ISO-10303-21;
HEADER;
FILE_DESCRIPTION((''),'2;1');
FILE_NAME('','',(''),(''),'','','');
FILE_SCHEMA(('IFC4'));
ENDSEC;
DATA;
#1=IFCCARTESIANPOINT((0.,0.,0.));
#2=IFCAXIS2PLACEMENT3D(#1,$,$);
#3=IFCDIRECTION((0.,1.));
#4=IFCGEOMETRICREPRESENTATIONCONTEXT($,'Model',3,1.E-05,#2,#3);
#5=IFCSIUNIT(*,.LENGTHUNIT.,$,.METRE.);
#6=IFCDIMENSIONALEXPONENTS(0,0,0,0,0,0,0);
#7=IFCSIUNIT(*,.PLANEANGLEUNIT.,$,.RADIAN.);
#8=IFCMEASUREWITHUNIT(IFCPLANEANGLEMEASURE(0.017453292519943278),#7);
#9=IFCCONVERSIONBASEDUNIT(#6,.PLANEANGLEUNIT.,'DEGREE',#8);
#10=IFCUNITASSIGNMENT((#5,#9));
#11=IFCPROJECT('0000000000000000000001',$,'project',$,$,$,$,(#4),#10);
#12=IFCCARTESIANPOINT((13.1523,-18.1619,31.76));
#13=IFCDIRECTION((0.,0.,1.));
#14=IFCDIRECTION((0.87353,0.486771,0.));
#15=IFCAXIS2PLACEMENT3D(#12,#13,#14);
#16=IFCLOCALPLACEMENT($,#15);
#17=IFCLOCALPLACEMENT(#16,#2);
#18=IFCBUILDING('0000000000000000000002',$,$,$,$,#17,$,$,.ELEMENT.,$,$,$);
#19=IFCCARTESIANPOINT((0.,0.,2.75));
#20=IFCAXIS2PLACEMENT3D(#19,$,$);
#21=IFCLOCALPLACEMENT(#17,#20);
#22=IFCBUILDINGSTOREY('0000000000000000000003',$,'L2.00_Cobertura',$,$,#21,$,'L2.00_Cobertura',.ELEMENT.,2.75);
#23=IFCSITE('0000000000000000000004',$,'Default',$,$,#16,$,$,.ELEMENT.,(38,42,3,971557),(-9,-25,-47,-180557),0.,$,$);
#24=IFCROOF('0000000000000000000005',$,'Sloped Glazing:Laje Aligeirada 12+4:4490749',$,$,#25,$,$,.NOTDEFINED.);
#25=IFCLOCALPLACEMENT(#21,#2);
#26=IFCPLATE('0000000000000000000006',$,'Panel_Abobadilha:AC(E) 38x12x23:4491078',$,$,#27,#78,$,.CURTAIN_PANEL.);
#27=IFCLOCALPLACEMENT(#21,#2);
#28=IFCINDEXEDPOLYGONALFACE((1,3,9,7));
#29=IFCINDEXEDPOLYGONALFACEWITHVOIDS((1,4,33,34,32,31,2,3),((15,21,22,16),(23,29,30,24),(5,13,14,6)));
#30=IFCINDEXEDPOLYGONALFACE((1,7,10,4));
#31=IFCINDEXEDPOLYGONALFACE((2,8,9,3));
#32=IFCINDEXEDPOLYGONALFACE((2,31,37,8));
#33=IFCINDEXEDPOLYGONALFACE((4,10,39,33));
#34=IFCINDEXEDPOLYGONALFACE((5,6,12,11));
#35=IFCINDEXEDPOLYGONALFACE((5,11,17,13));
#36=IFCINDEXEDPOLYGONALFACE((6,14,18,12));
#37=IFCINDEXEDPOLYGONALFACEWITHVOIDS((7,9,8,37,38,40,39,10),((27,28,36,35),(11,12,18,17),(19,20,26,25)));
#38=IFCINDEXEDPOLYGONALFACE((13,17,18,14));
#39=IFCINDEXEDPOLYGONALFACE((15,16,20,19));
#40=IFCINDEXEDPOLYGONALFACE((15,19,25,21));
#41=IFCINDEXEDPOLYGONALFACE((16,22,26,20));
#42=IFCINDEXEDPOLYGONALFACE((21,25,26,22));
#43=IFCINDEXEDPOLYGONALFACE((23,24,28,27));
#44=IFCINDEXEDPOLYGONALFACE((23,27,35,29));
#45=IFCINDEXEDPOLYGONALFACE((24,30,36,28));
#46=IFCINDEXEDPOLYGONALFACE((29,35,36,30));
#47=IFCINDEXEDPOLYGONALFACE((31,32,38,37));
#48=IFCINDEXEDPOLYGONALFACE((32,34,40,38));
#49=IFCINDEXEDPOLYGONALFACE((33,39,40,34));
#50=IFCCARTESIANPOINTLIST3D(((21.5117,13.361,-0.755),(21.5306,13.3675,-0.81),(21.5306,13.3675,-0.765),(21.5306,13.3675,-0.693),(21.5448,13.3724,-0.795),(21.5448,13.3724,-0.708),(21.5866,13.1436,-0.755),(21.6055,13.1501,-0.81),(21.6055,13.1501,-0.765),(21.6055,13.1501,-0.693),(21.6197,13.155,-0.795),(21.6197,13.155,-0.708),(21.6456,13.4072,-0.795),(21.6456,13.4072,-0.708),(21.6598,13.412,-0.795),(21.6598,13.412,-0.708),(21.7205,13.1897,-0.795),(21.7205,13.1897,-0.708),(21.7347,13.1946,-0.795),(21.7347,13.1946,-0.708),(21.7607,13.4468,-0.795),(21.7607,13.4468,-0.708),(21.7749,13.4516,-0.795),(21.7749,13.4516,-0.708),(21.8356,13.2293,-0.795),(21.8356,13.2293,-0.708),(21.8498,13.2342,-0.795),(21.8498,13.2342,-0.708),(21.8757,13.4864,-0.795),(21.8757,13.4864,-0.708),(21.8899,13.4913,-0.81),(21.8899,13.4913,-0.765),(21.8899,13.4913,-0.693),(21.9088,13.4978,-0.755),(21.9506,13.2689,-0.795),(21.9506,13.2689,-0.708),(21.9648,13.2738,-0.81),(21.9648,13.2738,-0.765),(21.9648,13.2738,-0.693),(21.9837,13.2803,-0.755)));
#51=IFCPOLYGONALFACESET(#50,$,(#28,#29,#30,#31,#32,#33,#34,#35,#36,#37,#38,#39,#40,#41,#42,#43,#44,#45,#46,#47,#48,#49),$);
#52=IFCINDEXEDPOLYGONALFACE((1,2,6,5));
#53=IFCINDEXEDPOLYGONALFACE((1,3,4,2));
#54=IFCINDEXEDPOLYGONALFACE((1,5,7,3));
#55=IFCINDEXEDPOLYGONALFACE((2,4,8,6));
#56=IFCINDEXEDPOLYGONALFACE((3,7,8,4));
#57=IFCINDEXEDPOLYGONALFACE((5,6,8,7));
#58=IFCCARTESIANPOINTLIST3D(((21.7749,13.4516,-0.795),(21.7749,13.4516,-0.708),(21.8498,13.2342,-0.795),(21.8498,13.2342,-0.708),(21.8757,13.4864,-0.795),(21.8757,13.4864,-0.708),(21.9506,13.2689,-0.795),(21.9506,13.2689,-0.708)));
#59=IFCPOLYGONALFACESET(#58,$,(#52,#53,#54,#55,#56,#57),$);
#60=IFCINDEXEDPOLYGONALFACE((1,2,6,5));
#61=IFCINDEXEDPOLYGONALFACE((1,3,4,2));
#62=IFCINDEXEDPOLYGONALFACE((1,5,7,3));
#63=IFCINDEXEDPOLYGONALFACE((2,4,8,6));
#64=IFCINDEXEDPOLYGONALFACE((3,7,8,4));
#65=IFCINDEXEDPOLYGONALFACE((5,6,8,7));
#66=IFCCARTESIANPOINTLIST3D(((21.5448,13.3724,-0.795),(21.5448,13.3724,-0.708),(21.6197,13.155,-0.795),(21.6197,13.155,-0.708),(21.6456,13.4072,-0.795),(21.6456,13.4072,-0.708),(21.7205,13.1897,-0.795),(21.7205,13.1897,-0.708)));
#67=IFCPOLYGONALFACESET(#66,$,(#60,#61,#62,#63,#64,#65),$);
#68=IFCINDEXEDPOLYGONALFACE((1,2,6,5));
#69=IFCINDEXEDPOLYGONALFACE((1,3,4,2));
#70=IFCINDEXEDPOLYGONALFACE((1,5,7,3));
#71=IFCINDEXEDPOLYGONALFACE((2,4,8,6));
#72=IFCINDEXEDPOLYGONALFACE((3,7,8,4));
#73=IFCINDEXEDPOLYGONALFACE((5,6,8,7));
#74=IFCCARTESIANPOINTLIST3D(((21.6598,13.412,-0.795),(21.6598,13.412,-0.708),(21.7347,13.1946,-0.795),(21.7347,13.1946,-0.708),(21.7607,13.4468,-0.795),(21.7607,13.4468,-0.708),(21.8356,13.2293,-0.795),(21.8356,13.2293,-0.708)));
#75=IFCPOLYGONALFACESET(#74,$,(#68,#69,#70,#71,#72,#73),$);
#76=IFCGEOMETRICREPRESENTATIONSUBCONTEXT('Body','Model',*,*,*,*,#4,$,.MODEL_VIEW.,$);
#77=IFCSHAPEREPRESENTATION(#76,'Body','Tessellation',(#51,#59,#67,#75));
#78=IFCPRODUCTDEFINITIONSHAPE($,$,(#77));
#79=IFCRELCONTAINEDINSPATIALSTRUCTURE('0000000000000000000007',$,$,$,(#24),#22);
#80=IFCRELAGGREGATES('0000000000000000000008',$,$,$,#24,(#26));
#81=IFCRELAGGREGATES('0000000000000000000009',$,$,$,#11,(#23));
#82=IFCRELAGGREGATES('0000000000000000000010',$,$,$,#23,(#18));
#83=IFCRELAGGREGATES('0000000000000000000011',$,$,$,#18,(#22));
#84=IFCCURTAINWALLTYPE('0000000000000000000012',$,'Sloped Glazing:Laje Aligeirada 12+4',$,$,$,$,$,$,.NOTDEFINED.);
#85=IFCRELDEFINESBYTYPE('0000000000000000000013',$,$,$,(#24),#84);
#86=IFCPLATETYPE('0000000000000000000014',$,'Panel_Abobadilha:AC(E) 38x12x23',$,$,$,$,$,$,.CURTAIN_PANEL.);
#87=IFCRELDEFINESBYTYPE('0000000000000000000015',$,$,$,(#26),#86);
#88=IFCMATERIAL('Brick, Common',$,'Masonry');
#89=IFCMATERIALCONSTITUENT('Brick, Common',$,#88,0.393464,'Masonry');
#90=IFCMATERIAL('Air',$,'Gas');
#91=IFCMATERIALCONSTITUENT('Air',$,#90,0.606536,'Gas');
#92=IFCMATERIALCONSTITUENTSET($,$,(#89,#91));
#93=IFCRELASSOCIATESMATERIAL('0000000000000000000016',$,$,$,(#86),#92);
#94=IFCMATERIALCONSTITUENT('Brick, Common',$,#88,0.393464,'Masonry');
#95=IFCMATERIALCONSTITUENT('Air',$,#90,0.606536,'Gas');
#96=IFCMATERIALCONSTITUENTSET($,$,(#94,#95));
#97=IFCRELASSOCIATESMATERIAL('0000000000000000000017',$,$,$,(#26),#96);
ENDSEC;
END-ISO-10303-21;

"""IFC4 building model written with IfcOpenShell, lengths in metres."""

from ifc_helpers import new_model, entity, si_unit, converted_unit, direction, frame, origin, place, context, subcontext, project, spatial, indexed_curve, outline, extrude, source, transform, mapped, material, constituent, constituent_set, type_object, type_shapes, element, aggregate, save


model = new_model("IFC4")

# Units and contexts
model_context = context("Model", 3, precision=1e-05, world=origin(), true_north=direction((0.0, 1.0)))
body_context = subcontext(model_context, "Body", "Model", "MODEL_VIEW")
ifc_project = project(units=[si_unit("LENGTHUNIT", "METRE"), converted_unit("PLANEANGLEUNIT", "DEGREE", entity("IfcPlaneAngleMeasure", 0.017453292519943278), si_unit("PLANEANGLEUNIT", "RADIAN"), dimensions=[0, 0, 0, 0, 0, 0, 0])], contexts=[model_context])

# Site, building, storey
site_placement = place(None, frame((13.1523, -18.1619, 31.76), z_axis=(0.0, 0.0, 1.0), x_axis=(0.87353, 0.486771, 0.0)))
site = spatial("IfcSite", under=ifc_project, at=site_placement, Name="Default", CompositionType="ELEMENT", RefLatitude=(38, 42, 3, 971557), RefLongitude=(-9, -25, -47, -180557), RefElevation=0.0)
building_placement = place(site_placement, origin())
building = spatial("IfcBuilding", under=site, at=building_placement, CompositionType="ELEMENT")
storey_placement = place(building_placement, frame((0.0, 0.0, 2.75)))
storey = spatial("IfcBuildingStorey", under=building, at=storey_placement, Name="L2.00_Cobertura", LongName="L2.00_Cobertura", CompositionType="ELEMENT", Elevation=2.75)

# Roof, plate
curtain_wall_type = type_object("IfcCurtainWallType", Name="Sloped Glazing:Laje Aligeirada 12+4", PredefinedType="NOTDEFINED")
roof_placement = place(storey_placement, frame((0.0, 0.0, -2.75)))
roof = element("IfcRoof", 1, at=roof_placement, inside=storey, type_object=curtain_wall_type, Name="Sloped Glazing:Laje Aligeirada 12+4:4490749", PredefinedType="NOTDEFINED")
ifc_material_1 = material(Name="Brick, Common", Category="Masonry")
ifc_material_2 = material(Name="Air", Category="Gas")
ifc_constituent_1 = constituent(ifc_material_1, Name="Brick, Common", Category="Masonry", fraction=0.393464)
ifc_constituent_2 = constituent(ifc_material_2, Name="Air", Category="Gas", fraction=0.606536)
ifc_constituent_set_1 = constituent_set(constituents=[ifc_constituent_1, ifc_constituent_2])
plate_type = type_object("IfcPlateType", Name="Panel_Abobadilha:AC(E) 38x12x23", PredefinedType="CURTAIN_PANEL", material=ifc_constituent_set_1)
shared_shape_1 = source(origin(), body_context, "Body", "SweptSolid", [
    extrude(outline(indexed_curve([(-0.19, -0.0543), (0.19, -0.0543), (0.19, -0.0093), (0.21, 0.0007), (0.19, 0.0628), (-0.19, 0.0628), (-0.21, 0.0007), (-0.19, -0.0093), (-0.19, -0.0543)], self_intersect=False), holes=[indexed_curve([(-0.0683, 0.0477), (-0.0683, -0.0393), (-0.175, -0.0393), (-0.175, 0.0477), (-0.0683, 0.0477)], self_intersect=False), indexed_curve([(0.0533, 0.0477), (0.0533, -0.0393), (-0.0533, -0.0393), (-0.0533, 0.0477), (0.0533, 0.0477)], self_intersect=False), indexed_curve([(0.175, 0.0477), (0.175, -0.0393), (0.0683, -0.0393), (0.0683, 0.0477), (0.175, 0.0477)], self_intersect=False)]), frame((0.0, 0.0543, 0.0)), (0.0, 0.0, 1.0), 0.23),
    extrude(outline(indexed_curve([(-0.0533, -0.0435), (0.0533, -0.0435), (0.0533, 0.0435), (-0.0533, 0.0435), (-0.0533, -0.0435)], self_intersect=False)), frame((0.1217, 0.0585, 0.0), z_axis=(0.0, 0.0, 1.0), x_axis=(-1.0, 0.0, 0.0)), (0.0, 0.0, 1.0), 0.23),
    extrude(outline(indexed_curve([(-0.0533, -0.0435), (0.0533, -0.0435), (0.0533, 0.0435), (-0.0533, 0.0435), (-0.0533, -0.0435)], self_intersect=False)), frame((-0.1217, 0.0585, 0.0), z_axis=(0.0, 0.0, 1.0), x_axis=(-1.0, 0.0, 0.0)), (0.0, 0.0, 1.0), 0.23),
    extrude(outline(indexed_curve([(-0.0533, -0.0435), (0.0533, -0.0435), (0.0533, 0.0435), (-0.0533, 0.0435), (-0.0533, -0.0435)], self_intersect=False)), frame((0.0, 0.0585, 0.0), z_axis=(0.0, 0.0, 1.0), x_axis=(-1.0, 0.0, 0.0)), (0.0, 0.0, 1.0), 0.23),
])
type_shapes(plate_type, [shared_shape_1])
ifc_constituent_3 = constituent(ifc_material_1, Name="Brick, Common", Category="Masonry", fraction=0.393464)
ifc_constituent_4 = constituent(ifc_material_2, Name="Air", Category="Gas", fraction=0.606536)
ifc_constituent_set_2 = constituent_set(constituents=[ifc_constituent_3, ifc_constituent_4])
plate_1_placement = place(roof_placement, frame((21.7103, 13.4294, 1.94), z_axis=(0.325568, -0.945519, 0.0), x_axis=(0.945519, 0.325568, 0.0)))
plate_1 = element("IfcPlate", 2, at=plate_1_placement, type_object=plate_type, material=ifc_constituent_set_2, Name="Panel_Abobadilha:AC(E) 38x12x23:4491078", PredefinedType="CURTAIN_PANEL", context=body_context, shape_type="MappedRepresentation", body=[
    mapped(shared_shape_1, transform((0.0, 0.0, 0.0), scale=1.0)),
])
aggregate(roof, [plate_1])

save(model, "model.ifc")
